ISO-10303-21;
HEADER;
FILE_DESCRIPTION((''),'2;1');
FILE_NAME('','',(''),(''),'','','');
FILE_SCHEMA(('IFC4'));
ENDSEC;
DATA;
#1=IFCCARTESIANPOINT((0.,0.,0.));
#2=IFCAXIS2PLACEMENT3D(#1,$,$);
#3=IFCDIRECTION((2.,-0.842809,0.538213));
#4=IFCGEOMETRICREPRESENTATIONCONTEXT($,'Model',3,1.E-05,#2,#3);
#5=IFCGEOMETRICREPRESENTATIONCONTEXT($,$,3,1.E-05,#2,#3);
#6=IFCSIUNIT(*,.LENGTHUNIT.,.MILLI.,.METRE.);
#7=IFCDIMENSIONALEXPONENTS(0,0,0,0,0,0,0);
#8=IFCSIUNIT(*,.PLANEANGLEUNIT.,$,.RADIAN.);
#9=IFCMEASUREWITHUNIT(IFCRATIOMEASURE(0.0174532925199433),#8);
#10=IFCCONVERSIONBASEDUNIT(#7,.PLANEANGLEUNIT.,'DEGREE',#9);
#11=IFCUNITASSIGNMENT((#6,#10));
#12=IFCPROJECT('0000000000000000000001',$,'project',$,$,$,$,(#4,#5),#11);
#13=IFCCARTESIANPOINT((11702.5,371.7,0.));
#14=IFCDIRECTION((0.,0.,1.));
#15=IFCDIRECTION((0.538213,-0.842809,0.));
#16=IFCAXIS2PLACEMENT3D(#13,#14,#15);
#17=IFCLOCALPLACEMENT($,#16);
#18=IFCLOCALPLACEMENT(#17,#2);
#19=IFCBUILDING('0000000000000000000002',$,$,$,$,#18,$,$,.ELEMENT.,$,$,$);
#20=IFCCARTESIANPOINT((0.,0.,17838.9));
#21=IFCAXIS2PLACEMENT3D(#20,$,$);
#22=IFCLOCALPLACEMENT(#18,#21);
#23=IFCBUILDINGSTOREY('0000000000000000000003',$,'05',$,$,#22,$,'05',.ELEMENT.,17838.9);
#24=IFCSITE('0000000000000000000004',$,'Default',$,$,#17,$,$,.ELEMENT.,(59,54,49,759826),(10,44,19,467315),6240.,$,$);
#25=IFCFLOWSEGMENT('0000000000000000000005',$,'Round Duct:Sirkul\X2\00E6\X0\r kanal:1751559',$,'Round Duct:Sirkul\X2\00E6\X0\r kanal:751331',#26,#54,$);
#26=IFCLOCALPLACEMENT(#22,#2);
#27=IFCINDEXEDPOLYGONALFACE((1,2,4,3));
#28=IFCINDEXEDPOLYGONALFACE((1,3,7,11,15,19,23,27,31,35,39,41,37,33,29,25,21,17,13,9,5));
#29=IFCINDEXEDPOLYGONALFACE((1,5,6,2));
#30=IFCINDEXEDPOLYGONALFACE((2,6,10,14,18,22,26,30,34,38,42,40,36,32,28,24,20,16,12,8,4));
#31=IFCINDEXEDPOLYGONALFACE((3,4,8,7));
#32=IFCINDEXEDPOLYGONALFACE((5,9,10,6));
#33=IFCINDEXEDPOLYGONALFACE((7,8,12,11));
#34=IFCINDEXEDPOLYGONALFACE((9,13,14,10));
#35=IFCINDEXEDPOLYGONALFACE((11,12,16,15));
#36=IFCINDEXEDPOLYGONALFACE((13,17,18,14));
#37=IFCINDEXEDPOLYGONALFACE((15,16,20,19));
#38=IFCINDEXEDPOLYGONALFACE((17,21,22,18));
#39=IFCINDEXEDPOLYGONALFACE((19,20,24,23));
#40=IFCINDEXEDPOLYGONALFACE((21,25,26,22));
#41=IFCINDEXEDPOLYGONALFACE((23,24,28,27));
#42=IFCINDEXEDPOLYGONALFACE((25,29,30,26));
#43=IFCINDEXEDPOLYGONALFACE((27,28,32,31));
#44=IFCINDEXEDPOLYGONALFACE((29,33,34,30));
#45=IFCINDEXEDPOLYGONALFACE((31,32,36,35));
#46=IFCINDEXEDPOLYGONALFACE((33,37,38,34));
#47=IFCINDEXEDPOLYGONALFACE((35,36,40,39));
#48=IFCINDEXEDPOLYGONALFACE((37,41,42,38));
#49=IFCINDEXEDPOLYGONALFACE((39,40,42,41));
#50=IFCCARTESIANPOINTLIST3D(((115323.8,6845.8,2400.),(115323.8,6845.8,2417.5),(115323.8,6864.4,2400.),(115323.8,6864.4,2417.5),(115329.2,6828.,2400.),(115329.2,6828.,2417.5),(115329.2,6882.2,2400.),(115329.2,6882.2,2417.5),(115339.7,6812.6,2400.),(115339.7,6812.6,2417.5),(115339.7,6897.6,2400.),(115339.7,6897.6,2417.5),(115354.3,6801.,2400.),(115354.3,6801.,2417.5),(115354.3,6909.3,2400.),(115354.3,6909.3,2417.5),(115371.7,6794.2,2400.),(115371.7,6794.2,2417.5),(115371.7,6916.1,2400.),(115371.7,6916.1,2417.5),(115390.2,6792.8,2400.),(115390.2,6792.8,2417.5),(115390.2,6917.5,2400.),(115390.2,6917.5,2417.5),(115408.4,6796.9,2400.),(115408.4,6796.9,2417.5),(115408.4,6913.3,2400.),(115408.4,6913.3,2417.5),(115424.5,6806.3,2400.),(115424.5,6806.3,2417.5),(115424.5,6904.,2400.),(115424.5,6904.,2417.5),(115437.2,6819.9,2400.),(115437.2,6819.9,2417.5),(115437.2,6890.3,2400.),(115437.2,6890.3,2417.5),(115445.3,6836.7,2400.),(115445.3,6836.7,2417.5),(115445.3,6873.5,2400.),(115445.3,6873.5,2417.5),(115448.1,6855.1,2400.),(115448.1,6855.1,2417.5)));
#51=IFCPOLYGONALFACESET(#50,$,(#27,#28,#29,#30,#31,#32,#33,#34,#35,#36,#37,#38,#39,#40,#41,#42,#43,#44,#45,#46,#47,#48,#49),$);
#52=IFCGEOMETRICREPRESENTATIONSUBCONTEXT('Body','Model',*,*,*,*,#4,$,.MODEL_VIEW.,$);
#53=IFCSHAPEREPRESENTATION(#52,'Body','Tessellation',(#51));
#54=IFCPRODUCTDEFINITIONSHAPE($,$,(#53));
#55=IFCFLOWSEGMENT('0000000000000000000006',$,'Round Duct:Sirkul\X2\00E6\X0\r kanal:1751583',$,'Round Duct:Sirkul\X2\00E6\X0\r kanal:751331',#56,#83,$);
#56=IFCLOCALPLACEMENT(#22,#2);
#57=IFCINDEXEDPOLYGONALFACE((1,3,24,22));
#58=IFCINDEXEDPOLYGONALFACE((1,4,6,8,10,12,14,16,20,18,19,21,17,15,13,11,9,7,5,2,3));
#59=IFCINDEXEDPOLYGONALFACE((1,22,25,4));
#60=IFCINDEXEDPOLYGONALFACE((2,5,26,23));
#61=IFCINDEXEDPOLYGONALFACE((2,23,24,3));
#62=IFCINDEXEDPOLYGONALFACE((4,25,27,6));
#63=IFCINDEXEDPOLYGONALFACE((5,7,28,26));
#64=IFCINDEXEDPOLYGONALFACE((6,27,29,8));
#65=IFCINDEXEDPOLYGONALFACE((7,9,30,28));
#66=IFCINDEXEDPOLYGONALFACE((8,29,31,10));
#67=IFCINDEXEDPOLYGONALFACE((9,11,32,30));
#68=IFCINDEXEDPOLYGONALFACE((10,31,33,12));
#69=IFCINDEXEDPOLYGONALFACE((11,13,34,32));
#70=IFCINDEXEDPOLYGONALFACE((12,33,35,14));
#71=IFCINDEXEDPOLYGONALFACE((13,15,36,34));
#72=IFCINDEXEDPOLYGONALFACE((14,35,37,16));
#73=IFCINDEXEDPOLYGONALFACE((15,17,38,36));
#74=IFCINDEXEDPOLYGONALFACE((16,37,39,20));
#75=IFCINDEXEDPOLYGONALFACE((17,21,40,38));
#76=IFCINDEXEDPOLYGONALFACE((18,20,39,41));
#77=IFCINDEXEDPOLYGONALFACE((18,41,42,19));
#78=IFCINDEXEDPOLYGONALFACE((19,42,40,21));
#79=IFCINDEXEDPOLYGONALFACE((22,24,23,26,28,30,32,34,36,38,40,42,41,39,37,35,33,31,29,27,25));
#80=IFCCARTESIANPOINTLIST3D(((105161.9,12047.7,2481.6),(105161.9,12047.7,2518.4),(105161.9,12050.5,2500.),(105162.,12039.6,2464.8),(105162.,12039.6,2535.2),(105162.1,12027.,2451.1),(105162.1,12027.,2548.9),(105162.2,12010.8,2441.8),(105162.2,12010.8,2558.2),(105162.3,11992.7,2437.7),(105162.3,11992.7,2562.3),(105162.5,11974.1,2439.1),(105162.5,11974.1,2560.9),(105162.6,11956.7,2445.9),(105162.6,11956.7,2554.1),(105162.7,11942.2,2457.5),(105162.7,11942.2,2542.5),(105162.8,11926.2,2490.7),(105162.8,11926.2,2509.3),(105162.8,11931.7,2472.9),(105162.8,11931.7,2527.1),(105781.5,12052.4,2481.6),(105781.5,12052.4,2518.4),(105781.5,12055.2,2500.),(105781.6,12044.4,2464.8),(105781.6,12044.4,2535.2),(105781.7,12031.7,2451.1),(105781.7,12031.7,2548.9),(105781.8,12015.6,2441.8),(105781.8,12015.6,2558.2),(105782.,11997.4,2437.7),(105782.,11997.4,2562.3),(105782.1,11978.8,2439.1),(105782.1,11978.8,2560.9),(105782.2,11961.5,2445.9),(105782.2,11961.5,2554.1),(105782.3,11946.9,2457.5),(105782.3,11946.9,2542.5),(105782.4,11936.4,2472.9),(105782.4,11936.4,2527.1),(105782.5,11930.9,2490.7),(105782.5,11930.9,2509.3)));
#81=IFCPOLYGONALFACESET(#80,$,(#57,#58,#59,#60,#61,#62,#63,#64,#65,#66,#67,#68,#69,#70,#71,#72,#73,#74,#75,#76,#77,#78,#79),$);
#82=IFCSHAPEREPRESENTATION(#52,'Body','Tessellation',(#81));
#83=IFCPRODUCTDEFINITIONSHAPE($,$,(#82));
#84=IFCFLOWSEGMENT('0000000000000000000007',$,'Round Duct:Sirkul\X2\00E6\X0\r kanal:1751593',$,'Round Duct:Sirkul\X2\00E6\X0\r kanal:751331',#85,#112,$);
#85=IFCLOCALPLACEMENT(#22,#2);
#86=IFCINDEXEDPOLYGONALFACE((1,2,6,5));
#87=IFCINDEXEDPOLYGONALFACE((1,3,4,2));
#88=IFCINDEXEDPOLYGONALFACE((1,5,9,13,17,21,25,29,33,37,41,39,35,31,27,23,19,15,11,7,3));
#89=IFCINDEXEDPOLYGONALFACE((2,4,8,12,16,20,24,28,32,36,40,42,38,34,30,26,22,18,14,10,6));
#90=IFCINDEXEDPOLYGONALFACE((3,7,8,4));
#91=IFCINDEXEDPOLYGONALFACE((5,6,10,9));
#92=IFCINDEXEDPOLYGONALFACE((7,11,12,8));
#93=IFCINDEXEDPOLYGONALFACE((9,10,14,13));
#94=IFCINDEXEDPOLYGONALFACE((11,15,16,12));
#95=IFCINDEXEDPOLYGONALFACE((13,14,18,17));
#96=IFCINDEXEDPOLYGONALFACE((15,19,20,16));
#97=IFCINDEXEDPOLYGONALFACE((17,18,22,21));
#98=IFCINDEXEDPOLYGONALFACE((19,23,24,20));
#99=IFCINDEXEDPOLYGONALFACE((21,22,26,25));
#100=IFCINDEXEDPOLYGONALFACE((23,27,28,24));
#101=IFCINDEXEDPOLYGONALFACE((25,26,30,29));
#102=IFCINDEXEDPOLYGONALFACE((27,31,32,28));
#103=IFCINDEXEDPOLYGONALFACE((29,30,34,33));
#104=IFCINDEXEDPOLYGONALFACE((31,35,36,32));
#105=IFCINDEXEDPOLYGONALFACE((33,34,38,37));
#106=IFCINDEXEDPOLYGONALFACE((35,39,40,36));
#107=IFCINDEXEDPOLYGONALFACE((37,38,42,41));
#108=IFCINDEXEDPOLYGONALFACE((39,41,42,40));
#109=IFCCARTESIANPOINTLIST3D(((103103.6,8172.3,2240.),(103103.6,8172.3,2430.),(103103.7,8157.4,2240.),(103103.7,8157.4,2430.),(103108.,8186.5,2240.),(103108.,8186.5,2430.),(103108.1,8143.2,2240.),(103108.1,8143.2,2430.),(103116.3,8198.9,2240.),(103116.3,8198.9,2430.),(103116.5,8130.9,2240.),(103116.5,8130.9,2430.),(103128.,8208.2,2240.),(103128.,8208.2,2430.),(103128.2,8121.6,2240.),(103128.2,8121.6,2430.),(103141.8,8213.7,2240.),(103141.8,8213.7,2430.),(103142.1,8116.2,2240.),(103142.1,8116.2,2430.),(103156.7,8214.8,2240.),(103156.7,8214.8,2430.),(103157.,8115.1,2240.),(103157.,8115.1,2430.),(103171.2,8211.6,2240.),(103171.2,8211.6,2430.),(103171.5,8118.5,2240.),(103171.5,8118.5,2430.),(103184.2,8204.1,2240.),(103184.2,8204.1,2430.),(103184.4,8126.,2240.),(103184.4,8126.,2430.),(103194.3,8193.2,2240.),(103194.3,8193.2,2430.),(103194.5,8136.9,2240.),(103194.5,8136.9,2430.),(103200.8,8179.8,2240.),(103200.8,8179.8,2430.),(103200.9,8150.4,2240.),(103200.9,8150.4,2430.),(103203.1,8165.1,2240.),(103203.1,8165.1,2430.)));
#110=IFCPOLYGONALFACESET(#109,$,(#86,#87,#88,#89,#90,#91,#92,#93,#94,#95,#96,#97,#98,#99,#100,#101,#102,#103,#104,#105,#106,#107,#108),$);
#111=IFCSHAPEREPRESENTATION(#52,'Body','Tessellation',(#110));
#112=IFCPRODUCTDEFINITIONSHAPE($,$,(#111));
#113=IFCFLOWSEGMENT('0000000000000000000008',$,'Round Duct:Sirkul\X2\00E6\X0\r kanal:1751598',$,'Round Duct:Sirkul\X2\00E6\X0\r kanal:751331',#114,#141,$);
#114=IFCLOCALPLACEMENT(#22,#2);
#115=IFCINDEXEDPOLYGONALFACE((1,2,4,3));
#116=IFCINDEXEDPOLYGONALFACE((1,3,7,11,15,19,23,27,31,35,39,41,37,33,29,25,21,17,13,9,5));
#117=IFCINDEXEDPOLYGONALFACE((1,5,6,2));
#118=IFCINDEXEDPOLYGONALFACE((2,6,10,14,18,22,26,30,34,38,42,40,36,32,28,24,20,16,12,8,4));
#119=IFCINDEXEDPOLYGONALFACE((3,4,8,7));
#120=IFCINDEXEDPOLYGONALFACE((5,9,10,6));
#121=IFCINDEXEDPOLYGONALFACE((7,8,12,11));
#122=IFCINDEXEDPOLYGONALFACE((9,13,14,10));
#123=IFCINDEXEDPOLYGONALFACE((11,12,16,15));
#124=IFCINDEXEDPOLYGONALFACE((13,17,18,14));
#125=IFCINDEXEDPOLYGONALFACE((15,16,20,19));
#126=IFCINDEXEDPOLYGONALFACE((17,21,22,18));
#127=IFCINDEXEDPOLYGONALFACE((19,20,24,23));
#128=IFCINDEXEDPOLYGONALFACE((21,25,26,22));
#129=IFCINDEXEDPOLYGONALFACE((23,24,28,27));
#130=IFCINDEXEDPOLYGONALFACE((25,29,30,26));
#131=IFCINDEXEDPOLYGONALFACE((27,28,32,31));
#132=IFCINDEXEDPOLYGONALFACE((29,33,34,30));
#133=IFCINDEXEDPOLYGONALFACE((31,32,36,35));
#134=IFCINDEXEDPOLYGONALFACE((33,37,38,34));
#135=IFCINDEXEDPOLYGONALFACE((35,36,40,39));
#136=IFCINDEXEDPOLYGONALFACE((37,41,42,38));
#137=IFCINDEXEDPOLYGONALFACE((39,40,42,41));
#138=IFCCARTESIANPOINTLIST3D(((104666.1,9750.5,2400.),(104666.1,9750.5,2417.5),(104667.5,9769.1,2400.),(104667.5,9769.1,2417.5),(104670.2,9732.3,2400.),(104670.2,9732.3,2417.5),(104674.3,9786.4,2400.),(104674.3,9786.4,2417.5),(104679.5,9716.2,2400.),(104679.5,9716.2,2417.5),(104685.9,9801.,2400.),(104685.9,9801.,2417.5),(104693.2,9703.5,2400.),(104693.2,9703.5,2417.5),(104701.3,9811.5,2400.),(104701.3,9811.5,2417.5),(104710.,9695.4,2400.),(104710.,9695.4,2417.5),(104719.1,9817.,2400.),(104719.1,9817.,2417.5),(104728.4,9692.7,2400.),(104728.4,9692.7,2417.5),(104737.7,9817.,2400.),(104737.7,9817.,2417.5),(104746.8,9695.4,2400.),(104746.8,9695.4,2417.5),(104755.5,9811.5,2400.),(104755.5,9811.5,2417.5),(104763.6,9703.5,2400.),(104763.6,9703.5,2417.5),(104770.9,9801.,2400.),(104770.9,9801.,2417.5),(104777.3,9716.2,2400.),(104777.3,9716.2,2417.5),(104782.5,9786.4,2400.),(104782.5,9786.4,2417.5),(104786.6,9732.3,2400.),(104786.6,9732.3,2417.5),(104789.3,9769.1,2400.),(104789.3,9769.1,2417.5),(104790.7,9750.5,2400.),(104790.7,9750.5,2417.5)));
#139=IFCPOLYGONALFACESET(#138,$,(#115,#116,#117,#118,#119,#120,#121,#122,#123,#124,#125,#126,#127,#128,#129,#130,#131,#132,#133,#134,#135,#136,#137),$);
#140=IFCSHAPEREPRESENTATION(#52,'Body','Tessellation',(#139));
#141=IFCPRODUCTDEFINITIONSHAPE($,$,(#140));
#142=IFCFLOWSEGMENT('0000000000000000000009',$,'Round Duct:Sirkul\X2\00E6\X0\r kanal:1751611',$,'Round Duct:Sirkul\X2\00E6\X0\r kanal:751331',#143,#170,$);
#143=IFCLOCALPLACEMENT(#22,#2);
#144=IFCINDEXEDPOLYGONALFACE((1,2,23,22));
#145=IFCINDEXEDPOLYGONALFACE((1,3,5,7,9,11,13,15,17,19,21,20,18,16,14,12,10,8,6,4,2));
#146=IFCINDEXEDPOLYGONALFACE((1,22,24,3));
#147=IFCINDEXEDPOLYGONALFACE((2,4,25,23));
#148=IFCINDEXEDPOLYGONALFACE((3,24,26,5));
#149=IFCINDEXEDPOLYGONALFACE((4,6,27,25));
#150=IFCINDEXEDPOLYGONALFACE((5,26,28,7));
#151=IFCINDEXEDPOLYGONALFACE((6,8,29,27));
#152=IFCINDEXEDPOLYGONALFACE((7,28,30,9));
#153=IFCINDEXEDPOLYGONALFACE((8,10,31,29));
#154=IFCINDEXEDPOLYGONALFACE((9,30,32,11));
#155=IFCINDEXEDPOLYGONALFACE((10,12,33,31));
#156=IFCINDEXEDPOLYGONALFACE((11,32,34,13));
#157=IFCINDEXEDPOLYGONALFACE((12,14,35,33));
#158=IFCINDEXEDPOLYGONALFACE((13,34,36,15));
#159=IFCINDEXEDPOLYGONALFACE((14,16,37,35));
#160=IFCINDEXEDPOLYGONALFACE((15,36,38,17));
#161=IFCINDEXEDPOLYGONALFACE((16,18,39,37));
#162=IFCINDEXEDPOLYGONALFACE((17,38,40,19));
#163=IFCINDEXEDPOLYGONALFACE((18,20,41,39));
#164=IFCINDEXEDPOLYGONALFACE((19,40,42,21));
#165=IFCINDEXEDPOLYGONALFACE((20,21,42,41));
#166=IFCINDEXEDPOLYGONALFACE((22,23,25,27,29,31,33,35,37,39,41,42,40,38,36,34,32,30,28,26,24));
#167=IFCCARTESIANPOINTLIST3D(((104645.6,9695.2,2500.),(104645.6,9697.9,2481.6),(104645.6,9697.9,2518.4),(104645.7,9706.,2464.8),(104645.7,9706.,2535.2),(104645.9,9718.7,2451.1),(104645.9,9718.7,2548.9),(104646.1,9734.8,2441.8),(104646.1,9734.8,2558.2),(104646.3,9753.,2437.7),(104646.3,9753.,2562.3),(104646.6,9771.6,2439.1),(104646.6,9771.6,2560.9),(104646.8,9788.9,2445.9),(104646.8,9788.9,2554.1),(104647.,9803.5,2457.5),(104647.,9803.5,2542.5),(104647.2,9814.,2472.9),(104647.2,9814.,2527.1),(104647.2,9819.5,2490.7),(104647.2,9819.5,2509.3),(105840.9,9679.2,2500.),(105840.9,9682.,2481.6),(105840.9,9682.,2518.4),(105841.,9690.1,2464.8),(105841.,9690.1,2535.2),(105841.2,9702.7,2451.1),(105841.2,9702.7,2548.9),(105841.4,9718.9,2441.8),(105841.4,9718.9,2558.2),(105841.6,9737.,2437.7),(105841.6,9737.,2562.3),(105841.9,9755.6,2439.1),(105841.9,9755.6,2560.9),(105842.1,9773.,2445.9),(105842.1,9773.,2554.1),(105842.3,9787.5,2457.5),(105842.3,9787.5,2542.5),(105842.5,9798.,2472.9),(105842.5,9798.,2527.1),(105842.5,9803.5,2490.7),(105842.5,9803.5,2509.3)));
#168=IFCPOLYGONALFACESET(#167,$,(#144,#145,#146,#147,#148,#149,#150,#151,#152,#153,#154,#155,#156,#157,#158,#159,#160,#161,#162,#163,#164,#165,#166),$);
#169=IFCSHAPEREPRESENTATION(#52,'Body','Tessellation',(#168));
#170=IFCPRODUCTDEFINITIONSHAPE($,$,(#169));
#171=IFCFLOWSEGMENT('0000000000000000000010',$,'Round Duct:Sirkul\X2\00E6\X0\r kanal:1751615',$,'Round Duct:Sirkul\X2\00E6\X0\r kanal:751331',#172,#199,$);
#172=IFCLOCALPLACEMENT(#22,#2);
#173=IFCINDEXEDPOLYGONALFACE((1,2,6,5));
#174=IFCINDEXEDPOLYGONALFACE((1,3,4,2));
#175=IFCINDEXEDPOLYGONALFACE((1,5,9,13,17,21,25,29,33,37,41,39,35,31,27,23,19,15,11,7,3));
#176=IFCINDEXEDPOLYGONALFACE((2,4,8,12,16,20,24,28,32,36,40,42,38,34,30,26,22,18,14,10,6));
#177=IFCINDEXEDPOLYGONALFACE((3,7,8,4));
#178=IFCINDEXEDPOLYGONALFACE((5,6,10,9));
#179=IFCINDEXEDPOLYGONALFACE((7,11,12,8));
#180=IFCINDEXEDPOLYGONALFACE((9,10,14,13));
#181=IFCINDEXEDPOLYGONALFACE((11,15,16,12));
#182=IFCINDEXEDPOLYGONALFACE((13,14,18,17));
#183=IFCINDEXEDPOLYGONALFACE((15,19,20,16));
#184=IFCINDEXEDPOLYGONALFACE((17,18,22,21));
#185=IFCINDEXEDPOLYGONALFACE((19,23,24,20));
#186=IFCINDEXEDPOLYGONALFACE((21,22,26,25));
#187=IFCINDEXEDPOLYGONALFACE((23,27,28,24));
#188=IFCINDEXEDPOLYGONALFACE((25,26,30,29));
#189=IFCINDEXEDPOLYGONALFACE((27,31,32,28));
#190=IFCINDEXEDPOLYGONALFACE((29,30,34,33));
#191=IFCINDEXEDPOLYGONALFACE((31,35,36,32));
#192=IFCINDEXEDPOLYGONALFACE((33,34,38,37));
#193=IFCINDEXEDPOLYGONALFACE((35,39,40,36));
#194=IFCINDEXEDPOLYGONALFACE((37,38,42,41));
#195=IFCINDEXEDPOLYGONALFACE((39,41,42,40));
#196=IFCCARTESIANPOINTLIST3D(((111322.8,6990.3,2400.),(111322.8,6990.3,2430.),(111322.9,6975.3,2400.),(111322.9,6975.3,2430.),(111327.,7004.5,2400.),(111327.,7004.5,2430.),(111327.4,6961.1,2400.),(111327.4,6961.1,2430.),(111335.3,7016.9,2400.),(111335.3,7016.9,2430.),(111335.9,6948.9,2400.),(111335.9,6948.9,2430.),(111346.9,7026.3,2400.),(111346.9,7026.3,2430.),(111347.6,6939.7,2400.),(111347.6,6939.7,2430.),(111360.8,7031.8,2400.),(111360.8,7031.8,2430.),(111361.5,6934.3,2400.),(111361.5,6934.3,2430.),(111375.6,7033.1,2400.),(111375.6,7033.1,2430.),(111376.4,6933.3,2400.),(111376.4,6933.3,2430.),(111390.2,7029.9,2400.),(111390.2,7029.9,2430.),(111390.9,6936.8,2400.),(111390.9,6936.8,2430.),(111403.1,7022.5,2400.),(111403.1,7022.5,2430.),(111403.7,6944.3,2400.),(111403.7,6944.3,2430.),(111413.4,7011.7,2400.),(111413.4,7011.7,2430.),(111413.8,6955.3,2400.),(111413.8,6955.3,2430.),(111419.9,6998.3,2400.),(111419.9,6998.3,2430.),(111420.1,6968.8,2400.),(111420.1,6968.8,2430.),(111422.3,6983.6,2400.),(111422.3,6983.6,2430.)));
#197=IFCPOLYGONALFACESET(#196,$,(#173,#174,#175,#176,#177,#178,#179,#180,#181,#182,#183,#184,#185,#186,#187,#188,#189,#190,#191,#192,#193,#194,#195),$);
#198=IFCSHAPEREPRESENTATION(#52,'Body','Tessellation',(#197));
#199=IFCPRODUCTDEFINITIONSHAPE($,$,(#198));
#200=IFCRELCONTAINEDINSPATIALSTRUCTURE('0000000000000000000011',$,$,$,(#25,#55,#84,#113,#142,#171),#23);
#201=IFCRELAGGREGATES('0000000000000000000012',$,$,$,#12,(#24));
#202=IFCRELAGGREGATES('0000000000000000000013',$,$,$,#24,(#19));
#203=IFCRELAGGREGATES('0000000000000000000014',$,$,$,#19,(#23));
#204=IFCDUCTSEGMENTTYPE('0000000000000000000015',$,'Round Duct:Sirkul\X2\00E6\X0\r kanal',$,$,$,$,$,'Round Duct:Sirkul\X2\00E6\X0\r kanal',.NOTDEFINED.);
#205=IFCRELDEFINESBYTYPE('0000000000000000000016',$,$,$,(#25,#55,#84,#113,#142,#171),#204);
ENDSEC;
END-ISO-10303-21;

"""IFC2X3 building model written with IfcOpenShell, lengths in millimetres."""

from ifc_helpers import new_model, entity, si_unit, converted_unit, direction, frame, frame_2d, origin, origin_2d_with_axis, place, context, subcontext, project, spatial, circle, extrude, type_object, element, save


model = new_model("IFC2X3")

# Units and contexts
model_context = context("Model", 3, precision=1e-05, world=origin(), true_north=direction((2.0, -0.842809, 0.538213)))
context_of_model = context(None, 3, precision=1e-05, world=origin(), true_north=direction((2.0, -0.842809, 0.538213)))
body_context = subcontext(model_context, "Body", "Model", "MODEL_VIEW")
ifc_project = project(units=[si_unit("LENGTHUNIT", "METRE", prefix="MILLI"), converted_unit("PLANEANGLEUNIT", "DEGREE", entity("IfcRatioMeasure", 0.0174532925199433), si_unit("PLANEANGLEUNIT", "RADIAN"), dimensions=[0, 0, 0, 0, 0, 0, 0])], contexts=[model_context, context_of_model])

# Site, building, storey
site_placement = place(None, frame((11702.5, 371.7, 0.0), z_axis=(0.0, 0.0, 1.0), x_axis=(0.538213, -0.842809, 0.0)))
site = spatial("IfcSite", under=ifc_project, at=site_placement, Name="Default", CompositionType="ELEMENT", RefLatitude=(59, 54, 49, 759826), RefLongitude=(10, 44, 19, 467315), RefElevation=6240.0)
building_placement = place(site_placement, origin())
building = spatial("IfcBuilding", under=site, at=building_placement, CompositionType="ELEMENT")
storey_placement = place(building_placement, frame((0.0, 0.0, 17838.9)))
storey = spatial("IfcBuildingStorey", under=building, at=storey_placement, Name="05", LongName="05", CompositionType="ELEMENT", Elevation=17838.9)

# Flow segments
duct_segment_type = type_object("IfcDuctSegmentType", Name="Round Duct:Sirkulær kanal", ElementType="Round Duct:Sirkulær kanal", PredefinedType="NOTDEFINED")
flow_segment_1_placement = place(storey_placement, origin())
element("IfcFlowSegment", 1, at=flow_segment_1_placement, inside=storey, type_object=duct_segment_type, Name="Round Duct:Sirkulær kanal:1751559", ObjectType="Round Duct:Sirkulær kanal:751331", context=body_context, shape_type="SweptSolid", body=[
    extrude(circle(Radius=62.5, at=frame_2d((0.0, 0.0), x_axis=(1.0, 0.0))), frame((115385.6, 6855.1, 2400.0)), (0.0, 0.0, 1.0), 17.5),
])
flow_segment_2_placement = place(storey_placement, origin())
element("IfcFlowSegment", 2, at=flow_segment_2_placement, inside=storey, type_object=duct_segment_type, Name="Round Duct:Sirkulær kanal:1751583", ObjectType="Round Duct:Sirkulær kanal:751331", context=body_context, shape_type="SweptSolid", body=[
    extrude(circle(Radius=62.5, at=origin_2d_with_axis()), frame((105162.3, 11988.0, 2500.0), z_axis=(0.999971, 0.007643, 0.0), x_axis=(-0.007643, 0.999971, 0.0)), (0.0, 0.0, 1.0), 619.7),
])
flow_segment_3_placement = place(storey_placement, origin())
element("IfcFlowSegment", 3, at=flow_segment_3_placement, inside=storey, type_object=duct_segment_type, Name="Round Duct:Sirkulær kanal:1751593", ObjectType="Round Duct:Sirkulær kanal:751331", context=body_context, shape_type="SweptSolid", body=[
    extrude(circle(Radius=50.0, at=frame_2d((0.0, 0.0), x_axis=(1.0, 0.0))), frame((103153.1, 8165.0, 2240.0), z_axis=(0.0, 0.0, 1.0), x_axis=(0.077379, -0.997002, 0.0)), (0.0, 0.0, 1.0), 190.0),
])
flow_segment_4_placement = place(storey_placement, origin())
element("IfcFlowSegment", 4, at=flow_segment_4_placement, inside=storey, type_object=duct_segment_type, Name="Round Duct:Sirkulær kanal:1751598", ObjectType="Round Duct:Sirkulær kanal:751331", context=body_context, shape_type="SweptSolid", body=[
    extrude(circle(Radius=62.5, at=frame_2d((0.0, 0.0), x_axis=(1.0, 0.0))), frame((104728.4, 9755.2, 2400.0), z_axis=(0.0, 0.0, 1.0), x_axis=(0.0, -1.0, 0.0)), (0.0, 0.0, 1.0), 17.5),
])
flow_segment_5_placement = place(storey_placement, origin())
element("IfcFlowSegment", 5, at=flow_segment_5_placement, inside=storey, type_object=duct_segment_type, Name="Round Duct:Sirkulær kanal:1751611", ObjectType="Round Duct:Sirkulær kanal:751331", context=body_context, shape_type="SweptSolid", body=[
    extrude(circle(Radius=62.5, at=origin_2d_with_axis()), frame((105841.7, 9741.7, 2500.0), z_axis=(-0.999911, 0.013345, 0.0), x_axis=(-0.013345, -0.999911, 0.0)), (0.0, 0.0, 1.0), 1195.4),
])
flow_segment_6_placement = place(storey_placement, origin())
element("IfcFlowSegment", 6, at=flow_segment_6_placement, inside=storey, type_object=duct_segment_type, Name="Round Duct:Sirkulær kanal:1751615", ObjectType="Round Duct:Sirkulær kanal:751331", context=body_context, shape_type="SweptSolid", body=[
    extrude(circle(Radius=50.0, at=frame_2d((0.0, 0.0), x_axis=(1.0, 0.0))), frame((111372.3, 6983.2, 2400.0), z_axis=(0.0, 0.0, 1.0), x_axis=(0.999971, 0.007643, 0.0)), (0.0, 0.0, 1.0), 30.0),
])

save(model, "model.ifc")
